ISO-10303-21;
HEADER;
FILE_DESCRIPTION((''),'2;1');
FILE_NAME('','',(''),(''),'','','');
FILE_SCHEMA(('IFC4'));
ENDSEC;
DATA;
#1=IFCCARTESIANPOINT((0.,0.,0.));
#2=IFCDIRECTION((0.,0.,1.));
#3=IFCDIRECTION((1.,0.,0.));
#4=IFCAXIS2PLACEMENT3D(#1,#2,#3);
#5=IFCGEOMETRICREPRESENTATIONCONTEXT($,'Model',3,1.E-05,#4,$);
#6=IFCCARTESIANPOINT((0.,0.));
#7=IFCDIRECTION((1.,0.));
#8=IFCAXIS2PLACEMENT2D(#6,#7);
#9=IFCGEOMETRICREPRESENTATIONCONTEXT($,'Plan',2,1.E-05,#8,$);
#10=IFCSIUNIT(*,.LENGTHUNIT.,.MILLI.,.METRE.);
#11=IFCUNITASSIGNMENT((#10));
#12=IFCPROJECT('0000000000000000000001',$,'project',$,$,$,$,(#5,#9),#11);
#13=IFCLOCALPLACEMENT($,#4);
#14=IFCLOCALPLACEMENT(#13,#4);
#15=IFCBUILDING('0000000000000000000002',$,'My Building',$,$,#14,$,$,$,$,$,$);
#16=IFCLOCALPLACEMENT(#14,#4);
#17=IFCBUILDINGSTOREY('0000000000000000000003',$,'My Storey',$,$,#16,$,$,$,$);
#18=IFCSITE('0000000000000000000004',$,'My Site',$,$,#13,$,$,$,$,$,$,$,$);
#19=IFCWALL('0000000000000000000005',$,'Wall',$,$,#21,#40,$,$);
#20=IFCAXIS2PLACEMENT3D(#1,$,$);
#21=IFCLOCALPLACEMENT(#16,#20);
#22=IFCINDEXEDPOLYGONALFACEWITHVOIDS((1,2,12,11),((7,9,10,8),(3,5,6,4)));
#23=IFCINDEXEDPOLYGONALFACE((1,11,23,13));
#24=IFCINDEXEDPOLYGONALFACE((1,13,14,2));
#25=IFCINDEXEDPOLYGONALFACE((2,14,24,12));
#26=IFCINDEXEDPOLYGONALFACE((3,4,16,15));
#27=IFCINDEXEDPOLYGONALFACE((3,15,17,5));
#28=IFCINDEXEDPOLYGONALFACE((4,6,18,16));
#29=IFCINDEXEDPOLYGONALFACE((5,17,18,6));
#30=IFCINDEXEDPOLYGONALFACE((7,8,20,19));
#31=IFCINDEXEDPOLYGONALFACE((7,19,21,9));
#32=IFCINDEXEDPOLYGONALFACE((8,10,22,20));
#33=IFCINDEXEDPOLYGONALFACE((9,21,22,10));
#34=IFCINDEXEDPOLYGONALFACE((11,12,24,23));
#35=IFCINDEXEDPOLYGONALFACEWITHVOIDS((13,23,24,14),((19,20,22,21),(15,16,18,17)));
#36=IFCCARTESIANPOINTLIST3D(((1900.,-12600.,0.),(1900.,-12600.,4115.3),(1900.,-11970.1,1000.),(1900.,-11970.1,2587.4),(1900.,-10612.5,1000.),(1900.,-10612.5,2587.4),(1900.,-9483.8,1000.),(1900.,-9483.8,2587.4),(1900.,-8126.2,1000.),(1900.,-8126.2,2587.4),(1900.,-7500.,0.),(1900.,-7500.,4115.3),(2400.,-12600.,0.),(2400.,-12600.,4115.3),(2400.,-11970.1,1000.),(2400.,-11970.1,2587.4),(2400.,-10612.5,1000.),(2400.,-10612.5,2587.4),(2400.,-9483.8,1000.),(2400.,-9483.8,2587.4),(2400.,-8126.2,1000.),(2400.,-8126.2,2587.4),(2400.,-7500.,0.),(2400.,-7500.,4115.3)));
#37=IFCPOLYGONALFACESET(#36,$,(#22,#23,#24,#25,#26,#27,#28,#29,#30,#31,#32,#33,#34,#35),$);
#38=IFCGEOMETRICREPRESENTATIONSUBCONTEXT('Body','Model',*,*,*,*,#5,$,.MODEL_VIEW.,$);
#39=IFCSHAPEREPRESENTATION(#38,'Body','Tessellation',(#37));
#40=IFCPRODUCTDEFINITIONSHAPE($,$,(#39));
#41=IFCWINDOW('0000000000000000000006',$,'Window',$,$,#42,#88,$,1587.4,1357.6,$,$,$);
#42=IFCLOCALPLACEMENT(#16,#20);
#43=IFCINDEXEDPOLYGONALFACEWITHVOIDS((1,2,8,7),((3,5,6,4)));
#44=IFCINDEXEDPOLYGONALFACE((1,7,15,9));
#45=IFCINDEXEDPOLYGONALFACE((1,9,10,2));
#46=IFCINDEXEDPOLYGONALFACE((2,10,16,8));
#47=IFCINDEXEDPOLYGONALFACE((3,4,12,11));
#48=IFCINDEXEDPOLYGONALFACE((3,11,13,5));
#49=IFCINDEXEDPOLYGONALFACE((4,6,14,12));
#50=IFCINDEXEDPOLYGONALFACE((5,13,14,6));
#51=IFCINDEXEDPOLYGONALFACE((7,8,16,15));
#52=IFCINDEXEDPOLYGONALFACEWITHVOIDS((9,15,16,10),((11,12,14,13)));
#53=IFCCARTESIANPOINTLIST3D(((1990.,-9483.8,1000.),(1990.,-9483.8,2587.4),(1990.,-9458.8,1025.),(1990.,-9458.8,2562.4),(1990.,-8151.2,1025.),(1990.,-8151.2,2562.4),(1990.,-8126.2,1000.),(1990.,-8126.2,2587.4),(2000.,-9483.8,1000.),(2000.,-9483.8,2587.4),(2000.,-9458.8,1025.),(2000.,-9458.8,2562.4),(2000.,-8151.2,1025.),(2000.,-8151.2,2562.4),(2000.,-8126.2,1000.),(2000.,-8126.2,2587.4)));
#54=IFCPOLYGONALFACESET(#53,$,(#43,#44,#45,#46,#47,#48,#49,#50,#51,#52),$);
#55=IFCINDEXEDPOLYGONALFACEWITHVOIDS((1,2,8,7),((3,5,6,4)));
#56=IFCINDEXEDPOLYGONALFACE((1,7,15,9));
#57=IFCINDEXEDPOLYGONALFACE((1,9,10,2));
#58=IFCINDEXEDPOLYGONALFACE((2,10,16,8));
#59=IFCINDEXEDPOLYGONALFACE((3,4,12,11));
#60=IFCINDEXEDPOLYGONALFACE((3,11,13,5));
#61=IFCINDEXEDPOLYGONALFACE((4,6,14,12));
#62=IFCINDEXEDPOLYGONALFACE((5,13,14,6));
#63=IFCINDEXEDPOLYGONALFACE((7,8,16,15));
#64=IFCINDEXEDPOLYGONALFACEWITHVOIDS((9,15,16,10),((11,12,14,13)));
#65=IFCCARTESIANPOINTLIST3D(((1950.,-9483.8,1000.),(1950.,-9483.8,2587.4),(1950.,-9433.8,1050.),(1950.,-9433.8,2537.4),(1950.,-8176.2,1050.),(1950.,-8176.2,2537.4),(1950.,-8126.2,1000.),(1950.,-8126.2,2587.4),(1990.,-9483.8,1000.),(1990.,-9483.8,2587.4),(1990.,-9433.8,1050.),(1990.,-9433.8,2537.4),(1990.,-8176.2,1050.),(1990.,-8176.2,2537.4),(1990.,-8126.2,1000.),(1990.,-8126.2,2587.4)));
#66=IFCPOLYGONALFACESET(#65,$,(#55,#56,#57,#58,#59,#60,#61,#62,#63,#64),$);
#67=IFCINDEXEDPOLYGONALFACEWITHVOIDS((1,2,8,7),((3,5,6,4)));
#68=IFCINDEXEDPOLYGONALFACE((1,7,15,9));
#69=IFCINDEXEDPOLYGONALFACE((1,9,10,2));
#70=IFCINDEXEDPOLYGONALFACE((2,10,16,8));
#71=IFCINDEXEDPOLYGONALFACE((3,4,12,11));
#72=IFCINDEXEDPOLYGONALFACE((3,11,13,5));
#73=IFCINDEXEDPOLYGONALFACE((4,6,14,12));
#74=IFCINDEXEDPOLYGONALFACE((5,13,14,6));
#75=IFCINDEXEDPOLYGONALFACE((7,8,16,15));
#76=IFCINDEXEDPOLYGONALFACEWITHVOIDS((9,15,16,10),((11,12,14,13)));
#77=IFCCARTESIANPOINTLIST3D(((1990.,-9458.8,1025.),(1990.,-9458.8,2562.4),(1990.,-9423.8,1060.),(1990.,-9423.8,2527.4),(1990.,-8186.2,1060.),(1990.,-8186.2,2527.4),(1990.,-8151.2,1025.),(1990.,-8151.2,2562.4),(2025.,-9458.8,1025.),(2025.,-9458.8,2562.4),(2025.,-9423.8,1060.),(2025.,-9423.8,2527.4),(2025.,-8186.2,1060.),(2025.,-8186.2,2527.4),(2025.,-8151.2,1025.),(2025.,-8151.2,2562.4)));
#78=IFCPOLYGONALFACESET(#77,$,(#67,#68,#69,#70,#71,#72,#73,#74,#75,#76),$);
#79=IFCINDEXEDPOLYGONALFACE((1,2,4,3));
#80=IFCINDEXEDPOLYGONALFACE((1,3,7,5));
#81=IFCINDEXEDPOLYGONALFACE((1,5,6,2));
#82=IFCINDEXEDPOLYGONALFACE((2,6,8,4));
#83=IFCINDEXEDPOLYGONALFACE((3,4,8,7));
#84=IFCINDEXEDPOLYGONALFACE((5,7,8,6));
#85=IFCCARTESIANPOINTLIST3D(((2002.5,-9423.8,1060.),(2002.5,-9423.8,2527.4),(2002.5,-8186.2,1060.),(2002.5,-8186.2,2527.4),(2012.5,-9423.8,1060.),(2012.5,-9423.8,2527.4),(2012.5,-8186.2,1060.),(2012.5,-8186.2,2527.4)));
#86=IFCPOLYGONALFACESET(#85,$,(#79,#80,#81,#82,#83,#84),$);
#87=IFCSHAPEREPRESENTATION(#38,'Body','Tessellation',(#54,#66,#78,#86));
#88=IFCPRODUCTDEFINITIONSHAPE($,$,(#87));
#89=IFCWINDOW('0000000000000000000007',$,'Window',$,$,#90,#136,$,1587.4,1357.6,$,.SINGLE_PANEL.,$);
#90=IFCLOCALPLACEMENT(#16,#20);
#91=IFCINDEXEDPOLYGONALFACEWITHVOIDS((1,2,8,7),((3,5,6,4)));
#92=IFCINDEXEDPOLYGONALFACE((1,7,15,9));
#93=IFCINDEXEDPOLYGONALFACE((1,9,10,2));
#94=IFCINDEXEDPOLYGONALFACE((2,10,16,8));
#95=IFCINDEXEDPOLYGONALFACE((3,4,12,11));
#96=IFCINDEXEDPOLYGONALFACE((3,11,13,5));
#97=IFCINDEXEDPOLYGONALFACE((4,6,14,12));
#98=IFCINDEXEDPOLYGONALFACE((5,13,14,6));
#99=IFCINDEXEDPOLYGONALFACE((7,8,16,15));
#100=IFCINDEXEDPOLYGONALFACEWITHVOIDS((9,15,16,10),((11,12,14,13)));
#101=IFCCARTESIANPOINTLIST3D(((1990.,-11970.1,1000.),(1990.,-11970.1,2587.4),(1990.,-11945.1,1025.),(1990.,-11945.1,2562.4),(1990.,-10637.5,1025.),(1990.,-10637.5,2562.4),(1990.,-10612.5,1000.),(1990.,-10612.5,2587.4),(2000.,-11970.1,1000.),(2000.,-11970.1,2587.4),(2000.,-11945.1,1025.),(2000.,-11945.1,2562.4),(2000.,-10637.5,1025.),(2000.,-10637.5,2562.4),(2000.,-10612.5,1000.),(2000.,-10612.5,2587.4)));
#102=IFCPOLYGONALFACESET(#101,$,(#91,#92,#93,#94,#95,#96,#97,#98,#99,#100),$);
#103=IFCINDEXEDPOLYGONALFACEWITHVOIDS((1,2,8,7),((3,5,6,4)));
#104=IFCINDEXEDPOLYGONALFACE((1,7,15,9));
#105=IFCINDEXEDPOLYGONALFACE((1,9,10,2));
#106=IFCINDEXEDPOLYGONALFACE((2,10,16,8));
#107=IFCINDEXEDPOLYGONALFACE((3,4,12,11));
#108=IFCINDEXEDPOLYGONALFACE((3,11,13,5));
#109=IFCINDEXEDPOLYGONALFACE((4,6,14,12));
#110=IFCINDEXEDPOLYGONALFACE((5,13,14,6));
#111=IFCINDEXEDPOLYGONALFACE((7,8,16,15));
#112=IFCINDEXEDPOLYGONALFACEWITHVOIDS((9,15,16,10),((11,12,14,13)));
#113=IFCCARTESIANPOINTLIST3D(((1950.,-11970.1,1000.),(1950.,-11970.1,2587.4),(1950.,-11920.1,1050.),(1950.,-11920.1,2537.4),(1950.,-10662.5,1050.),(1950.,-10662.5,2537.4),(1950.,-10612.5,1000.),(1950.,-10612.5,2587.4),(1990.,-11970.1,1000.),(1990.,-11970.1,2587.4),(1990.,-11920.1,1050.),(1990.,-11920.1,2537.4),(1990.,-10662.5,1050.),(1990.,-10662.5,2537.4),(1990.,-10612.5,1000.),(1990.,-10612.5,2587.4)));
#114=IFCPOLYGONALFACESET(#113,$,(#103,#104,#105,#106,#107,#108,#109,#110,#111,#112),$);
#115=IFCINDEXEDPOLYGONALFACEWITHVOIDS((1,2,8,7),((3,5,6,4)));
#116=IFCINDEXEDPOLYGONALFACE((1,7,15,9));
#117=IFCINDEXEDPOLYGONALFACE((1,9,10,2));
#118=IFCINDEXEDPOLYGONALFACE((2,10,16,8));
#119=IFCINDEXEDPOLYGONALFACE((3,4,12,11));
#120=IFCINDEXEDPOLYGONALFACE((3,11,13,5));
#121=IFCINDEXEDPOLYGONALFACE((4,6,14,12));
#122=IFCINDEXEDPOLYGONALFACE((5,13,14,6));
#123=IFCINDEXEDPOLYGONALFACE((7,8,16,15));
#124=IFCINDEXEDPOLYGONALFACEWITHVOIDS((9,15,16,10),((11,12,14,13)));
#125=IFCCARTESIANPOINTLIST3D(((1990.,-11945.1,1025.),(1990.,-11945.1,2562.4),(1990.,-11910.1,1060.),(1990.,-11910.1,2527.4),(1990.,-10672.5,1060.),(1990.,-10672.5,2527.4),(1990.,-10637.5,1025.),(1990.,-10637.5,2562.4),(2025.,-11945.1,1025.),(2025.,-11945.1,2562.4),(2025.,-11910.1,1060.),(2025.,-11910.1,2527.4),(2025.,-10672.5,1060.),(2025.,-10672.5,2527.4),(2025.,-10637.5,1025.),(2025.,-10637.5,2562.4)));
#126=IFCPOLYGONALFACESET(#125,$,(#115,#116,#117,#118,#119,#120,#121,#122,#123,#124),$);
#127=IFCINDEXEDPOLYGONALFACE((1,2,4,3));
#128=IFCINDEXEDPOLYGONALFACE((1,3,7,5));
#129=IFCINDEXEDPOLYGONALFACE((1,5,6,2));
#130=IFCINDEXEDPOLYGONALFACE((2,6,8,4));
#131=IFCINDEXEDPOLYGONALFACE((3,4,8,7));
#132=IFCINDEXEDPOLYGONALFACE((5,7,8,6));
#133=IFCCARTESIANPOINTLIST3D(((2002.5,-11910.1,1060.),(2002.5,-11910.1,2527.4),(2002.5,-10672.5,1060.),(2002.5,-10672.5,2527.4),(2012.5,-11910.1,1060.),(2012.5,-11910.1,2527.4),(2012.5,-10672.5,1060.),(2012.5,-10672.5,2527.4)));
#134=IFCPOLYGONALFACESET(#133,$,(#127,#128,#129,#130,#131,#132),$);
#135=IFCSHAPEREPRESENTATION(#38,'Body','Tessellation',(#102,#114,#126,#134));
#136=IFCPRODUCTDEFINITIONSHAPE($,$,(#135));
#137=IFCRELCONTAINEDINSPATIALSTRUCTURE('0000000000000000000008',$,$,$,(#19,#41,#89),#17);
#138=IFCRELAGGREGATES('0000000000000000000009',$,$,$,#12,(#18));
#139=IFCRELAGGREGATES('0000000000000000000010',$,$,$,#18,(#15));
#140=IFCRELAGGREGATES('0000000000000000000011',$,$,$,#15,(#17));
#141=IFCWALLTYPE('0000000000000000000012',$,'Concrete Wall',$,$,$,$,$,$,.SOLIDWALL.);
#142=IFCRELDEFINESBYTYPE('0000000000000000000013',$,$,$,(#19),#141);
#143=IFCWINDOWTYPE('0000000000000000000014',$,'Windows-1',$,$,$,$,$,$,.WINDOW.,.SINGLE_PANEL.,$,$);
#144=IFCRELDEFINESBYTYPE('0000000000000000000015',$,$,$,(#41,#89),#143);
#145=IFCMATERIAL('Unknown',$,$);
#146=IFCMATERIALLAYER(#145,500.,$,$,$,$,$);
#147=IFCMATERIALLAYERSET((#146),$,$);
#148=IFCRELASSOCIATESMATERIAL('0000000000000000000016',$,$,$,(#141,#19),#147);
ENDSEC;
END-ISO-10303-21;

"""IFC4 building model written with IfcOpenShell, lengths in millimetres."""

from ifc_helpers import new_model, entity, si_unit, frame, origin_with_axes, origin_2d_with_axis, place, context, subcontext, project, spatial, line, indexed_curve, outline, extrude, shape, source, transform, mapped, material, layer, layer_set, layer_usage, type_object, type_shapes, element, fill, save


model = new_model("IFC4")

# Units and contexts
model_context = context("Model", 3, precision=1e-05, world=origin_with_axes())
plan_context = context("Plan", 2, precision=1e-05, world=origin_2d_with_axis())
body_context_1 = subcontext(model_context, "Body", "Model", "MODEL_VIEW")
body_context_2 = subcontext(plan_context, "Body", "Plan", "PLAN_VIEW")
ifc_project = project(units=[si_unit("LENGTHUNIT", "METRE", prefix="MILLI")], contexts=[model_context, plan_context])

# Site, building, storey
site_placement = place(None, origin_with_axes())
site = spatial("IfcSite", under=ifc_project, at=site_placement, Name="My Site")
building_placement = place(site_placement, origin_with_axes())
building = spatial("IfcBuilding", under=site, at=building_placement, Name="My Building")
storey_placement = place(building_placement, origin_with_axes())
storey = spatial("IfcBuildingStorey", under=building, at=storey_placement, Name="My Storey")

# Shared definitions
ifc_material = material(Name="Unknown")

# Wall, openings, windows
ifc_layer_1 = layer(ifc_material, 500.0)
ifc_layer_set_1 = layer_set([ifc_layer_1])
wall_type = type_object("IfcWallType", Name="Concrete Wall", PredefinedType="SOLIDWALL", material=ifc_layer_set_1)
shared_shape_1 = source(origin_with_axes(), body_context_1, "Body", "SweptSolid", [
    extrude(outline(indexed_curve([(0.0, 0.0), (1357.6, 0.0), (1357.6, 1587.4), (0.0, 1587.4)], segments=[line(1, 2, 3, 4, 1)])), frame((0.0, -600.0, 0.0), z_axis=(0.0, -1.0, 0.0), x_axis=(1.0, 0.0, 0.0)), (0.0, 0.0, -1.0), 1200.0),
])
window_type = type_object("IfcWindowType", Name="Windows-1", PartitioningType="SINGLE_PANEL", PredefinedType="WINDOW")
shared_shape_2 = source(origin_with_axes(), body_context_1, "Body", "SweptSolid", [
    extrude(outline(indexed_curve([(0.0, 0.0), (1357.6, 0.0), (1357.6, 1587.4), (0.0, 1587.4)], segments=[line(1, 2, 3, 4, 1)]), holes=[indexed_curve([(25.0, 25.0), (1332.6, 25.0), (1332.6, 1562.4), (25.0, 1562.4)], segments=[line(1, 2, 3, 4, 1)])]), frame((0.0, 90.0, 0.0), z_axis=(0.0, -1.0, 0.0), x_axis=(1.0, 0.0, 0.0)), (0.0, 0.0, -1.0), 10.0),
    extrude(outline(indexed_curve([(0.0, 0.0), (1357.6, 0.0), (1357.6, 1587.4), (0.0, 1587.4)], segments=[line(1, 2, 3, 4, 1)]), holes=[indexed_curve([(50.0, 50.0), (1307.6, 50.0), (1307.6, 1537.4), (50.0, 1537.4)], segments=[line(1, 2, 3, 4, 1)])]), frame((0.0, 50.0, 0.0), z_axis=(0.0, -1.0, 0.0), x_axis=(1.0, 0.0, 0.0)), (0.0, 0.0, -1.0), 40.0),
    extrude(outline(indexed_curve([(0.0, 0.0), (1307.6, 0.0), (1307.6, 1537.4), (0.0, 1537.4)], segments=[line(1, 2, 3, 4, 1)]), holes=[indexed_curve([(35.0, 35.0), (1272.6, 35.0), (1272.6, 1502.4), (35.0, 1502.4)], segments=[line(1, 2, 3, 4, 1)])]), frame((25.0, 90.0, 25.0), z_axis=(0.0, -1.0, 0.0), x_axis=(1.0, 0.0, 0.0)), (0.0, 0.0, -1.0), 35.0),
    extrude(outline(indexed_curve([(35.0, 35.0), (1272.6, 35.0), (1272.6, 1502.4), (35.0, 1502.4)], segments=[line(1, 2, 3, 4, 1)])), frame((25.0, 102.5, 25.0), z_axis=(0.0, -1.0, 0.0), x_axis=(1.0, 0.0, 0.0)), (0.0, 0.0, -1.0), 10.0),
])
shared_shape_3 = source(origin_with_axes(), body_context_2, "Body", "Curve2D", [
    entity("IfcIndexedPolyCurve", entity("IfcCartesianPointList2D", [[50.0, 50.0], [1307.6, 50.0]])),
    entity("IfcIndexedPolyCurve", entity("IfcCartesianPointList2D", [[0.0, 100.0], [25.0, 100.0], [25.0, 90.0], [50.0, 90.0], [50.0, 50.0], [0.0, 50.0]]), [entity("IfcLineIndex", [1, 2, 3, 4, 5, 6, 1])]),
    entity("IfcIndexedPolyCurve", entity("IfcCartesianPointList2D", [[1357.6, 100.0], [1332.6, 100.0], [1332.6, 90.0], [1307.6, 90.0], [1307.6, 50.0], [1357.6, 50.0]]), [entity("IfcLineIndex", [1, 2, 3, 4, 5, 6, 1])]),
    entity("IfcIndexedPolyCurve", entity("IfcCartesianPointList2D", [[25.0, 90.0], [60.0, 90.0], [60.0, 125.0], [25.0, 125.0]]), [entity("IfcLineIndex", [1, 2, 3, 4, 1])]),
    entity("IfcIndexedPolyCurve", entity("IfcCartesianPointList2D", [[1332.6, 90.0], [1297.6, 90.0], [1297.6, 125.0], [1332.6, 125.0]]), [entity("IfcLineIndex", [1, 2, 3, 4, 1])]),
    entity("IfcIndexedPolyCurve", entity("IfcCartesianPointList2D", [[60.0, 90.0], [1297.6, 90.0]])),
    entity("IfcIndexedPolyCurve", entity("IfcCartesianPointList2D", [[60.0, 125.0], [1297.6, 125.0]])),
    entity("IfcIndexedPolyCurve", entity("IfcCartesianPointList2D", [[60.0, 107.5], [1297.6, 107.5]])),
])
type_shapes(window_type, [shared_shape_2, shared_shape_3])
ifc_layer_usage_1 = layer_usage(ifc_layer_set_1, "AXIS2", "POSITIVE", 0.0)
wall_1_placement = place(storey_placement, frame((1900.0, -7500.0, 0.0), z_axis=(0.0, 0.0, 1.0), x_axis=(0.0, -1.0, 0.0)))
wall_1 = element("IfcWall", 1, at=wall_1_placement, inside=storey, type_object=wall_type, material=ifc_layer_usage_1, Name="Wall", context=body_context_1, shape_type="SweptSolid", body=[
    extrude(outline(indexed_curve([(0.0, 0.0), (0.0, 500.0), (5100.0, 500.0), (5100.0, 0.0)], segments=[line(1, 2, 3, 4, 1)])), origin_with_axes(), (0.0, 0.0, 1.0), 4115.3),
])
opening_1_placement = place(wall_1_placement, frame((626.2, 0.0, 1000.0), z_axis=(0.0, 0.0, 1.0), x_axis=(1.0, 0.0, 0.0)))
opening_1 = element("IfcOpeningElement", 2, at=opening_1_placement, cuts=wall_1, PredefinedType="OPENING", context=body_context_1, shape_type="MappedRepresentation", body=[
    mapped(shared_shape_1, transform((0.0, 0.0, 0.0), x_axis=(1.0, 0.0, 0.0), y_axis=(0.0, 1.0, 0.0), z_axis=(0.0, 0.0, 1.0), scale=1.0)),
])
opening_2_placement = place(wall_1_placement, frame((3112.5, 0.0, 1000.0), z_axis=(0.0, 0.0, 1.0), x_axis=(1.0, 0.0, 0.0)))
opening_2 = element("IfcOpeningElement", 3, at=opening_2_placement, cuts=wall_1, PredefinedType="OPENING", context=body_context_1, shape_type="MappedRepresentation", body=[
    mapped(shared_shape_1, transform((0.0, 0.0, 0.0), x_axis=(1.0, 0.0, 0.0), y_axis=(0.0, 1.0, 0.0), z_axis=(0.0, 0.0, 1.0), scale=1.0)),
])
window_1_placement = place(opening_1_placement, frame((0.0, 0.0, 0.0), z_axis=(0.0, 0.0, 1.0), x_axis=(1.0, 0.0, 0.0)))
window_1 = element("IfcWindow", 4, at=window_1_placement, inside=storey, type_object=window_type, Name="Window", OverallHeight=1587.4, OverallWidth=1357.6, shapes=[
    shape(body_context_1, "Body", "MappedRepresentation", [mapped(shared_shape_2, transform((0.0, 0.0, 0.0), x_axis=(1.0, 0.0, 0.0), y_axis=(0.0, 1.0, 0.0), z_axis=(0.0, 0.0, 1.0), scale=1.0))]),
    shape(body_context_2, "Body", "MappedRepresentation", [mapped(shared_shape_3, transform((0.0, 0.0, 0.0), x_axis=(1.0, 0.0, 0.0), y_axis=(0.0, 1.0, 0.0), z_axis=(0.0, 0.0, 1.0), scale=1.0))]),
])
fill(opening_1, window_1)
window_2_placement = place(opening_2_placement, frame((0.0, 0.0, 0.0), z_axis=(0.0, 0.0, 1.0), x_axis=(1.0, 0.0, 0.0)))
window_2 = element("IfcWindow", 5, at=window_2_placement, inside=storey, type_object=window_type, Name="Window", OverallHeight=1587.4, OverallWidth=1357.6, PartitioningType="SINGLE_PANEL", shapes=[
    shape(body_context_1, "Body", "MappedRepresentation", [mapped(shared_shape_2, transform((0.0, 0.0, 0.0), x_axis=(1.0, 0.0, 0.0), y_axis=(0.0, 1.0, 0.0), z_axis=(0.0, 0.0, 1.0), scale=1.0))]),
    shape(body_context_2, "Body", "MappedRepresentation", [mapped(shared_shape_3, transform((0.0, 0.0, 0.0), x_axis=(1.0, 0.0, 0.0), y_axis=(0.0, 1.0, 0.0), z_axis=(0.0, 0.0, 1.0), scale=1.0))]),
])
fill(opening_2, window_2)

save(model, "model.ifc")
